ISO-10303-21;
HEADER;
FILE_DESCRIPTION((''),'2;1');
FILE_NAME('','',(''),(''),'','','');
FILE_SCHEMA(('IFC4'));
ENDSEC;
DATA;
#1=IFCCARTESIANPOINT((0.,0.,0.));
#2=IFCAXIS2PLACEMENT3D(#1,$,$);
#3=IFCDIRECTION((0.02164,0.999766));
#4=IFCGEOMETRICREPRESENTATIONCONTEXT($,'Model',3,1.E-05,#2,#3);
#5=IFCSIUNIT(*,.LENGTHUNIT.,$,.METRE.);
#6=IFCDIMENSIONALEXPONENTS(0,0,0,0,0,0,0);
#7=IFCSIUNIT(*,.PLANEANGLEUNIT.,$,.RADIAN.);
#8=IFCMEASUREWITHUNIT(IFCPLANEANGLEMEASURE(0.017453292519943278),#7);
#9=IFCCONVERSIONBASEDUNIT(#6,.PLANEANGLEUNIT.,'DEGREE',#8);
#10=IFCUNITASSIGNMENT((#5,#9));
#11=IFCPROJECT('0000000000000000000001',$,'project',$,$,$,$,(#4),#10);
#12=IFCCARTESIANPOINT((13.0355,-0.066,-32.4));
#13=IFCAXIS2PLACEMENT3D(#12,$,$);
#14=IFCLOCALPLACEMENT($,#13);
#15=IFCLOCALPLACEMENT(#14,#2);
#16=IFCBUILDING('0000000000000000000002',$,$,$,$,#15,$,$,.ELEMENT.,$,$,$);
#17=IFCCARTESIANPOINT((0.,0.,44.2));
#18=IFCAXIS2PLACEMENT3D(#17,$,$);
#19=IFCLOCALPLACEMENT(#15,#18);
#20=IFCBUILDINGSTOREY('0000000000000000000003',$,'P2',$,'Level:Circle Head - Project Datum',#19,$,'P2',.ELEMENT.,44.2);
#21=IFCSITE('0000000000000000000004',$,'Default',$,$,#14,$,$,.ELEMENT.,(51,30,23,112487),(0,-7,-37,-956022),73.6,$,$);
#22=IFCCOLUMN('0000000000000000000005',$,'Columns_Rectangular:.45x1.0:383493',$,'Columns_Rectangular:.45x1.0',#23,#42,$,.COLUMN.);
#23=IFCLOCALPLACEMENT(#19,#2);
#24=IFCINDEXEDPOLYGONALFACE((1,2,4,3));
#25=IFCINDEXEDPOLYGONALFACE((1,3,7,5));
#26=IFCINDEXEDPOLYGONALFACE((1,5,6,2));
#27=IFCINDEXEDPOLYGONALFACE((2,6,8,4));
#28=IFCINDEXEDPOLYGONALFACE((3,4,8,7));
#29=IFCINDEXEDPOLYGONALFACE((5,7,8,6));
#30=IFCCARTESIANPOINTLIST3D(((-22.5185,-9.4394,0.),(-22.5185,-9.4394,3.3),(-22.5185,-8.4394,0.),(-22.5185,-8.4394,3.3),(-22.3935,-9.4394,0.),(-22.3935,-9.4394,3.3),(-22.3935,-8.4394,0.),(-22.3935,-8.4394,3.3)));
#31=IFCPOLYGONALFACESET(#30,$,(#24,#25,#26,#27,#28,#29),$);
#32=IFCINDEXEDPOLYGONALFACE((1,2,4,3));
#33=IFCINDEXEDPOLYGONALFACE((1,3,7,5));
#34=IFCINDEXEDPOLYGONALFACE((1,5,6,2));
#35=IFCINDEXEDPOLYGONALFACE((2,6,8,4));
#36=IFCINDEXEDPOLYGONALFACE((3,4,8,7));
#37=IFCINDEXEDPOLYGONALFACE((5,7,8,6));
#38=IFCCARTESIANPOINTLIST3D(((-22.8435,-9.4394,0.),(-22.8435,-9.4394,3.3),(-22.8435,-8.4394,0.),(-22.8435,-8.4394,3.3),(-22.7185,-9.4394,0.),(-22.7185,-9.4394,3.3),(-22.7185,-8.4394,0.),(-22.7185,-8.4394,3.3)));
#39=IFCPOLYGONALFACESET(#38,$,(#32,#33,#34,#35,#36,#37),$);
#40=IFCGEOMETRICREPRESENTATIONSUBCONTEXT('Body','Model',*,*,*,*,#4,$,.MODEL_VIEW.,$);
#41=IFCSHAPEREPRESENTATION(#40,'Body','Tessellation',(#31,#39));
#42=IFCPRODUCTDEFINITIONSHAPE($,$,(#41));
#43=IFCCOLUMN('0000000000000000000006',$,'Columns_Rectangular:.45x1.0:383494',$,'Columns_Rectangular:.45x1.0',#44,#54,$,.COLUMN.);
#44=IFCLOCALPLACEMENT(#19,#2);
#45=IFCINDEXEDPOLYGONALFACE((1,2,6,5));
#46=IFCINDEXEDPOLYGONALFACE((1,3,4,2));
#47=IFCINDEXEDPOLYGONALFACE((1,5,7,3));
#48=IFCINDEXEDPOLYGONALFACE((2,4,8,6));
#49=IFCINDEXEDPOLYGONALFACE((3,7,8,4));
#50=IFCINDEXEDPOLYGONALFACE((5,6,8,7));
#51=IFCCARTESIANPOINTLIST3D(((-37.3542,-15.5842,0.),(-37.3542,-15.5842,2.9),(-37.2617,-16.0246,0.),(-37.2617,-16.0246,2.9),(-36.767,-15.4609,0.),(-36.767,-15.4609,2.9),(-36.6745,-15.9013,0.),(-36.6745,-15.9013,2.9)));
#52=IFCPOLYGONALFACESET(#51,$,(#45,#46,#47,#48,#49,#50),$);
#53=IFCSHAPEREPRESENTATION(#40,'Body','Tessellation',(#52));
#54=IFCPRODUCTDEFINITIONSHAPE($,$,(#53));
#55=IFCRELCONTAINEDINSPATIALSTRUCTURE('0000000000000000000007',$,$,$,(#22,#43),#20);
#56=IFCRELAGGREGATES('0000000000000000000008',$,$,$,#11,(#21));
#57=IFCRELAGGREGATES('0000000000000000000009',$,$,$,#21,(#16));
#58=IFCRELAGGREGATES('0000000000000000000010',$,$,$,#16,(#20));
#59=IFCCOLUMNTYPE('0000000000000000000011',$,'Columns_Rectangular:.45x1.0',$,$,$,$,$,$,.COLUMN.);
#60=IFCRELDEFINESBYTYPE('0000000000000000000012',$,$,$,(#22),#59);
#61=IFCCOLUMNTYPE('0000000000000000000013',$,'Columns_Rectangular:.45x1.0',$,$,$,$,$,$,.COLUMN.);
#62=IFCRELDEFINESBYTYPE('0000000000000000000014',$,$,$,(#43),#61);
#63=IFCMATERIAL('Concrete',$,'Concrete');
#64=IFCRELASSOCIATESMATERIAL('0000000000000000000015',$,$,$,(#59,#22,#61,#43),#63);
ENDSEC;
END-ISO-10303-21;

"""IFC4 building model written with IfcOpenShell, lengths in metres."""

from ifc_helpers import new_model, entity, si_unit, converted_unit, direction, frame, origin, place, context, subcontext, project, spatial, indexed_curve, outline, extrude, source, transform, mapped, material, type_object, type_shapes, element, save


model = new_model("IFC4")

# Units and contexts
model_context = context("Model", 3, precision=1e-05, world=origin(), true_north=direction((0.02164, 0.999766)))
body_context = subcontext(model_context, "Body", "Model", "MODEL_VIEW")
ifc_project = project(units=[si_unit("LENGTHUNIT", "METRE"), converted_unit("PLANEANGLEUNIT", "DEGREE", entity("IfcPlaneAngleMeasure", 0.017453292519943278), si_unit("PLANEANGLEUNIT", "RADIAN"), dimensions=[0, 0, 0, 0, 0, 0, 0])], contexts=[model_context])

# Site, building, storey
site_placement = place(None, frame((13.0355, -0.066, -32.4)))
site = spatial("IfcSite", under=ifc_project, at=site_placement, Name="Default", CompositionType="ELEMENT", RefLatitude=(51, 30, 23, 112487), RefLongitude=(0, -7, -37, -956022), RefElevation=73.6)
building_placement = place(site_placement, origin())
building = spatial("IfcBuilding", under=site, at=building_placement, CompositionType="ELEMENT")
storey_placement = place(building_placement, frame((0.0, 0.0, 44.2)))
storey = spatial("IfcBuildingStorey", under=building, at=storey_placement, Name="P2", ObjectType="Level:Circle Head - Project Datum", LongName="P2", CompositionType="ELEMENT", Elevation=44.2)

# Columns
ifc_material = material(Name="Concrete", Category="Concrete")
column_type_1 = type_object("IfcColumnType", Name="Columns_Rectangular:.45x1.0", PredefinedType="COLUMN", material=ifc_material)
shared_shape_1 = source(origin(), body_context, "Body", "SweptSolid", [
    extrude(outline(indexed_curve([(-0.0625, -0.5), (0.0625, -0.5), (0.0625, 0.5), (-0.0625, 0.5), (-0.0625, -0.5)], self_intersect=False)), frame((-22.456, -8.9394, 44.2), z_axis=(0.0, 0.0, 1.0), x_axis=(-1.0, 0.0, 0.0)), (0.0, 0.0, 1.0), 3.3),
    extrude(outline(indexed_curve([(-0.0625, -0.5), (0.0625, -0.5), (0.0625, 0.5), (-0.0625, 0.5), (-0.0625, -0.5)], self_intersect=False)), frame((-22.781, -8.9394, 44.2)), (0.0, 0.0, 1.0), 3.3),
])
type_shapes(column_type_1, [shared_shape_1])
column_1_placement = place(storey_placement, frame((0.0, 0.0, -44.2)))
element("IfcColumn", 1, at=column_1_placement, inside=storey, type_object=column_type_1, material=ifc_material, Name="Columns_Rectangular:.45x1.0:383493", ObjectType="Columns_Rectangular:.45x1.0", PredefinedType="COLUMN", context=body_context, shape_type="MappedRepresentation", body=[
    mapped(shared_shape_1, transform((0.0, 0.0, 0.0), scale=1.0)),
])
column_type_2 = type_object("IfcColumnType", Name="Columns_Rectangular:.45x1.0", PredefinedType="COLUMN", material=ifc_material)
shared_shape_2 = source(origin(), body_context, "Body", "SweptSolid", [
    extrude(outline(indexed_curve([(-0.3, -0.225), (0.3, -0.225), (0.3, 0.225), (-0.3, 0.225), (-0.3, -0.225)], self_intersect=False)), frame((-37.0144, -15.7427, 44.2), z_axis=(0.0, 0.0, 1.0), x_axis=(0.978657, 0.2055, 0.0)), (0.0, 0.0, 1.0), 2.9),
])
type_shapes(column_type_2, [shared_shape_2])
column_2_placement = place(storey_placement, frame((0.0, 0.0, -44.2)))
element("IfcColumn", 2, at=column_2_placement, inside=storey, type_object=column_type_2, material=ifc_material, Name="Columns_Rectangular:.45x1.0:383494", ObjectType="Columns_Rectangular:.45x1.0", PredefinedType="COLUMN", context=body_context, shape_type="MappedRepresentation", body=[
    mapped(shared_shape_2, transform((0.0, 0.0, 0.0), scale=1.0)),
])

save(model, "model.ifc")
